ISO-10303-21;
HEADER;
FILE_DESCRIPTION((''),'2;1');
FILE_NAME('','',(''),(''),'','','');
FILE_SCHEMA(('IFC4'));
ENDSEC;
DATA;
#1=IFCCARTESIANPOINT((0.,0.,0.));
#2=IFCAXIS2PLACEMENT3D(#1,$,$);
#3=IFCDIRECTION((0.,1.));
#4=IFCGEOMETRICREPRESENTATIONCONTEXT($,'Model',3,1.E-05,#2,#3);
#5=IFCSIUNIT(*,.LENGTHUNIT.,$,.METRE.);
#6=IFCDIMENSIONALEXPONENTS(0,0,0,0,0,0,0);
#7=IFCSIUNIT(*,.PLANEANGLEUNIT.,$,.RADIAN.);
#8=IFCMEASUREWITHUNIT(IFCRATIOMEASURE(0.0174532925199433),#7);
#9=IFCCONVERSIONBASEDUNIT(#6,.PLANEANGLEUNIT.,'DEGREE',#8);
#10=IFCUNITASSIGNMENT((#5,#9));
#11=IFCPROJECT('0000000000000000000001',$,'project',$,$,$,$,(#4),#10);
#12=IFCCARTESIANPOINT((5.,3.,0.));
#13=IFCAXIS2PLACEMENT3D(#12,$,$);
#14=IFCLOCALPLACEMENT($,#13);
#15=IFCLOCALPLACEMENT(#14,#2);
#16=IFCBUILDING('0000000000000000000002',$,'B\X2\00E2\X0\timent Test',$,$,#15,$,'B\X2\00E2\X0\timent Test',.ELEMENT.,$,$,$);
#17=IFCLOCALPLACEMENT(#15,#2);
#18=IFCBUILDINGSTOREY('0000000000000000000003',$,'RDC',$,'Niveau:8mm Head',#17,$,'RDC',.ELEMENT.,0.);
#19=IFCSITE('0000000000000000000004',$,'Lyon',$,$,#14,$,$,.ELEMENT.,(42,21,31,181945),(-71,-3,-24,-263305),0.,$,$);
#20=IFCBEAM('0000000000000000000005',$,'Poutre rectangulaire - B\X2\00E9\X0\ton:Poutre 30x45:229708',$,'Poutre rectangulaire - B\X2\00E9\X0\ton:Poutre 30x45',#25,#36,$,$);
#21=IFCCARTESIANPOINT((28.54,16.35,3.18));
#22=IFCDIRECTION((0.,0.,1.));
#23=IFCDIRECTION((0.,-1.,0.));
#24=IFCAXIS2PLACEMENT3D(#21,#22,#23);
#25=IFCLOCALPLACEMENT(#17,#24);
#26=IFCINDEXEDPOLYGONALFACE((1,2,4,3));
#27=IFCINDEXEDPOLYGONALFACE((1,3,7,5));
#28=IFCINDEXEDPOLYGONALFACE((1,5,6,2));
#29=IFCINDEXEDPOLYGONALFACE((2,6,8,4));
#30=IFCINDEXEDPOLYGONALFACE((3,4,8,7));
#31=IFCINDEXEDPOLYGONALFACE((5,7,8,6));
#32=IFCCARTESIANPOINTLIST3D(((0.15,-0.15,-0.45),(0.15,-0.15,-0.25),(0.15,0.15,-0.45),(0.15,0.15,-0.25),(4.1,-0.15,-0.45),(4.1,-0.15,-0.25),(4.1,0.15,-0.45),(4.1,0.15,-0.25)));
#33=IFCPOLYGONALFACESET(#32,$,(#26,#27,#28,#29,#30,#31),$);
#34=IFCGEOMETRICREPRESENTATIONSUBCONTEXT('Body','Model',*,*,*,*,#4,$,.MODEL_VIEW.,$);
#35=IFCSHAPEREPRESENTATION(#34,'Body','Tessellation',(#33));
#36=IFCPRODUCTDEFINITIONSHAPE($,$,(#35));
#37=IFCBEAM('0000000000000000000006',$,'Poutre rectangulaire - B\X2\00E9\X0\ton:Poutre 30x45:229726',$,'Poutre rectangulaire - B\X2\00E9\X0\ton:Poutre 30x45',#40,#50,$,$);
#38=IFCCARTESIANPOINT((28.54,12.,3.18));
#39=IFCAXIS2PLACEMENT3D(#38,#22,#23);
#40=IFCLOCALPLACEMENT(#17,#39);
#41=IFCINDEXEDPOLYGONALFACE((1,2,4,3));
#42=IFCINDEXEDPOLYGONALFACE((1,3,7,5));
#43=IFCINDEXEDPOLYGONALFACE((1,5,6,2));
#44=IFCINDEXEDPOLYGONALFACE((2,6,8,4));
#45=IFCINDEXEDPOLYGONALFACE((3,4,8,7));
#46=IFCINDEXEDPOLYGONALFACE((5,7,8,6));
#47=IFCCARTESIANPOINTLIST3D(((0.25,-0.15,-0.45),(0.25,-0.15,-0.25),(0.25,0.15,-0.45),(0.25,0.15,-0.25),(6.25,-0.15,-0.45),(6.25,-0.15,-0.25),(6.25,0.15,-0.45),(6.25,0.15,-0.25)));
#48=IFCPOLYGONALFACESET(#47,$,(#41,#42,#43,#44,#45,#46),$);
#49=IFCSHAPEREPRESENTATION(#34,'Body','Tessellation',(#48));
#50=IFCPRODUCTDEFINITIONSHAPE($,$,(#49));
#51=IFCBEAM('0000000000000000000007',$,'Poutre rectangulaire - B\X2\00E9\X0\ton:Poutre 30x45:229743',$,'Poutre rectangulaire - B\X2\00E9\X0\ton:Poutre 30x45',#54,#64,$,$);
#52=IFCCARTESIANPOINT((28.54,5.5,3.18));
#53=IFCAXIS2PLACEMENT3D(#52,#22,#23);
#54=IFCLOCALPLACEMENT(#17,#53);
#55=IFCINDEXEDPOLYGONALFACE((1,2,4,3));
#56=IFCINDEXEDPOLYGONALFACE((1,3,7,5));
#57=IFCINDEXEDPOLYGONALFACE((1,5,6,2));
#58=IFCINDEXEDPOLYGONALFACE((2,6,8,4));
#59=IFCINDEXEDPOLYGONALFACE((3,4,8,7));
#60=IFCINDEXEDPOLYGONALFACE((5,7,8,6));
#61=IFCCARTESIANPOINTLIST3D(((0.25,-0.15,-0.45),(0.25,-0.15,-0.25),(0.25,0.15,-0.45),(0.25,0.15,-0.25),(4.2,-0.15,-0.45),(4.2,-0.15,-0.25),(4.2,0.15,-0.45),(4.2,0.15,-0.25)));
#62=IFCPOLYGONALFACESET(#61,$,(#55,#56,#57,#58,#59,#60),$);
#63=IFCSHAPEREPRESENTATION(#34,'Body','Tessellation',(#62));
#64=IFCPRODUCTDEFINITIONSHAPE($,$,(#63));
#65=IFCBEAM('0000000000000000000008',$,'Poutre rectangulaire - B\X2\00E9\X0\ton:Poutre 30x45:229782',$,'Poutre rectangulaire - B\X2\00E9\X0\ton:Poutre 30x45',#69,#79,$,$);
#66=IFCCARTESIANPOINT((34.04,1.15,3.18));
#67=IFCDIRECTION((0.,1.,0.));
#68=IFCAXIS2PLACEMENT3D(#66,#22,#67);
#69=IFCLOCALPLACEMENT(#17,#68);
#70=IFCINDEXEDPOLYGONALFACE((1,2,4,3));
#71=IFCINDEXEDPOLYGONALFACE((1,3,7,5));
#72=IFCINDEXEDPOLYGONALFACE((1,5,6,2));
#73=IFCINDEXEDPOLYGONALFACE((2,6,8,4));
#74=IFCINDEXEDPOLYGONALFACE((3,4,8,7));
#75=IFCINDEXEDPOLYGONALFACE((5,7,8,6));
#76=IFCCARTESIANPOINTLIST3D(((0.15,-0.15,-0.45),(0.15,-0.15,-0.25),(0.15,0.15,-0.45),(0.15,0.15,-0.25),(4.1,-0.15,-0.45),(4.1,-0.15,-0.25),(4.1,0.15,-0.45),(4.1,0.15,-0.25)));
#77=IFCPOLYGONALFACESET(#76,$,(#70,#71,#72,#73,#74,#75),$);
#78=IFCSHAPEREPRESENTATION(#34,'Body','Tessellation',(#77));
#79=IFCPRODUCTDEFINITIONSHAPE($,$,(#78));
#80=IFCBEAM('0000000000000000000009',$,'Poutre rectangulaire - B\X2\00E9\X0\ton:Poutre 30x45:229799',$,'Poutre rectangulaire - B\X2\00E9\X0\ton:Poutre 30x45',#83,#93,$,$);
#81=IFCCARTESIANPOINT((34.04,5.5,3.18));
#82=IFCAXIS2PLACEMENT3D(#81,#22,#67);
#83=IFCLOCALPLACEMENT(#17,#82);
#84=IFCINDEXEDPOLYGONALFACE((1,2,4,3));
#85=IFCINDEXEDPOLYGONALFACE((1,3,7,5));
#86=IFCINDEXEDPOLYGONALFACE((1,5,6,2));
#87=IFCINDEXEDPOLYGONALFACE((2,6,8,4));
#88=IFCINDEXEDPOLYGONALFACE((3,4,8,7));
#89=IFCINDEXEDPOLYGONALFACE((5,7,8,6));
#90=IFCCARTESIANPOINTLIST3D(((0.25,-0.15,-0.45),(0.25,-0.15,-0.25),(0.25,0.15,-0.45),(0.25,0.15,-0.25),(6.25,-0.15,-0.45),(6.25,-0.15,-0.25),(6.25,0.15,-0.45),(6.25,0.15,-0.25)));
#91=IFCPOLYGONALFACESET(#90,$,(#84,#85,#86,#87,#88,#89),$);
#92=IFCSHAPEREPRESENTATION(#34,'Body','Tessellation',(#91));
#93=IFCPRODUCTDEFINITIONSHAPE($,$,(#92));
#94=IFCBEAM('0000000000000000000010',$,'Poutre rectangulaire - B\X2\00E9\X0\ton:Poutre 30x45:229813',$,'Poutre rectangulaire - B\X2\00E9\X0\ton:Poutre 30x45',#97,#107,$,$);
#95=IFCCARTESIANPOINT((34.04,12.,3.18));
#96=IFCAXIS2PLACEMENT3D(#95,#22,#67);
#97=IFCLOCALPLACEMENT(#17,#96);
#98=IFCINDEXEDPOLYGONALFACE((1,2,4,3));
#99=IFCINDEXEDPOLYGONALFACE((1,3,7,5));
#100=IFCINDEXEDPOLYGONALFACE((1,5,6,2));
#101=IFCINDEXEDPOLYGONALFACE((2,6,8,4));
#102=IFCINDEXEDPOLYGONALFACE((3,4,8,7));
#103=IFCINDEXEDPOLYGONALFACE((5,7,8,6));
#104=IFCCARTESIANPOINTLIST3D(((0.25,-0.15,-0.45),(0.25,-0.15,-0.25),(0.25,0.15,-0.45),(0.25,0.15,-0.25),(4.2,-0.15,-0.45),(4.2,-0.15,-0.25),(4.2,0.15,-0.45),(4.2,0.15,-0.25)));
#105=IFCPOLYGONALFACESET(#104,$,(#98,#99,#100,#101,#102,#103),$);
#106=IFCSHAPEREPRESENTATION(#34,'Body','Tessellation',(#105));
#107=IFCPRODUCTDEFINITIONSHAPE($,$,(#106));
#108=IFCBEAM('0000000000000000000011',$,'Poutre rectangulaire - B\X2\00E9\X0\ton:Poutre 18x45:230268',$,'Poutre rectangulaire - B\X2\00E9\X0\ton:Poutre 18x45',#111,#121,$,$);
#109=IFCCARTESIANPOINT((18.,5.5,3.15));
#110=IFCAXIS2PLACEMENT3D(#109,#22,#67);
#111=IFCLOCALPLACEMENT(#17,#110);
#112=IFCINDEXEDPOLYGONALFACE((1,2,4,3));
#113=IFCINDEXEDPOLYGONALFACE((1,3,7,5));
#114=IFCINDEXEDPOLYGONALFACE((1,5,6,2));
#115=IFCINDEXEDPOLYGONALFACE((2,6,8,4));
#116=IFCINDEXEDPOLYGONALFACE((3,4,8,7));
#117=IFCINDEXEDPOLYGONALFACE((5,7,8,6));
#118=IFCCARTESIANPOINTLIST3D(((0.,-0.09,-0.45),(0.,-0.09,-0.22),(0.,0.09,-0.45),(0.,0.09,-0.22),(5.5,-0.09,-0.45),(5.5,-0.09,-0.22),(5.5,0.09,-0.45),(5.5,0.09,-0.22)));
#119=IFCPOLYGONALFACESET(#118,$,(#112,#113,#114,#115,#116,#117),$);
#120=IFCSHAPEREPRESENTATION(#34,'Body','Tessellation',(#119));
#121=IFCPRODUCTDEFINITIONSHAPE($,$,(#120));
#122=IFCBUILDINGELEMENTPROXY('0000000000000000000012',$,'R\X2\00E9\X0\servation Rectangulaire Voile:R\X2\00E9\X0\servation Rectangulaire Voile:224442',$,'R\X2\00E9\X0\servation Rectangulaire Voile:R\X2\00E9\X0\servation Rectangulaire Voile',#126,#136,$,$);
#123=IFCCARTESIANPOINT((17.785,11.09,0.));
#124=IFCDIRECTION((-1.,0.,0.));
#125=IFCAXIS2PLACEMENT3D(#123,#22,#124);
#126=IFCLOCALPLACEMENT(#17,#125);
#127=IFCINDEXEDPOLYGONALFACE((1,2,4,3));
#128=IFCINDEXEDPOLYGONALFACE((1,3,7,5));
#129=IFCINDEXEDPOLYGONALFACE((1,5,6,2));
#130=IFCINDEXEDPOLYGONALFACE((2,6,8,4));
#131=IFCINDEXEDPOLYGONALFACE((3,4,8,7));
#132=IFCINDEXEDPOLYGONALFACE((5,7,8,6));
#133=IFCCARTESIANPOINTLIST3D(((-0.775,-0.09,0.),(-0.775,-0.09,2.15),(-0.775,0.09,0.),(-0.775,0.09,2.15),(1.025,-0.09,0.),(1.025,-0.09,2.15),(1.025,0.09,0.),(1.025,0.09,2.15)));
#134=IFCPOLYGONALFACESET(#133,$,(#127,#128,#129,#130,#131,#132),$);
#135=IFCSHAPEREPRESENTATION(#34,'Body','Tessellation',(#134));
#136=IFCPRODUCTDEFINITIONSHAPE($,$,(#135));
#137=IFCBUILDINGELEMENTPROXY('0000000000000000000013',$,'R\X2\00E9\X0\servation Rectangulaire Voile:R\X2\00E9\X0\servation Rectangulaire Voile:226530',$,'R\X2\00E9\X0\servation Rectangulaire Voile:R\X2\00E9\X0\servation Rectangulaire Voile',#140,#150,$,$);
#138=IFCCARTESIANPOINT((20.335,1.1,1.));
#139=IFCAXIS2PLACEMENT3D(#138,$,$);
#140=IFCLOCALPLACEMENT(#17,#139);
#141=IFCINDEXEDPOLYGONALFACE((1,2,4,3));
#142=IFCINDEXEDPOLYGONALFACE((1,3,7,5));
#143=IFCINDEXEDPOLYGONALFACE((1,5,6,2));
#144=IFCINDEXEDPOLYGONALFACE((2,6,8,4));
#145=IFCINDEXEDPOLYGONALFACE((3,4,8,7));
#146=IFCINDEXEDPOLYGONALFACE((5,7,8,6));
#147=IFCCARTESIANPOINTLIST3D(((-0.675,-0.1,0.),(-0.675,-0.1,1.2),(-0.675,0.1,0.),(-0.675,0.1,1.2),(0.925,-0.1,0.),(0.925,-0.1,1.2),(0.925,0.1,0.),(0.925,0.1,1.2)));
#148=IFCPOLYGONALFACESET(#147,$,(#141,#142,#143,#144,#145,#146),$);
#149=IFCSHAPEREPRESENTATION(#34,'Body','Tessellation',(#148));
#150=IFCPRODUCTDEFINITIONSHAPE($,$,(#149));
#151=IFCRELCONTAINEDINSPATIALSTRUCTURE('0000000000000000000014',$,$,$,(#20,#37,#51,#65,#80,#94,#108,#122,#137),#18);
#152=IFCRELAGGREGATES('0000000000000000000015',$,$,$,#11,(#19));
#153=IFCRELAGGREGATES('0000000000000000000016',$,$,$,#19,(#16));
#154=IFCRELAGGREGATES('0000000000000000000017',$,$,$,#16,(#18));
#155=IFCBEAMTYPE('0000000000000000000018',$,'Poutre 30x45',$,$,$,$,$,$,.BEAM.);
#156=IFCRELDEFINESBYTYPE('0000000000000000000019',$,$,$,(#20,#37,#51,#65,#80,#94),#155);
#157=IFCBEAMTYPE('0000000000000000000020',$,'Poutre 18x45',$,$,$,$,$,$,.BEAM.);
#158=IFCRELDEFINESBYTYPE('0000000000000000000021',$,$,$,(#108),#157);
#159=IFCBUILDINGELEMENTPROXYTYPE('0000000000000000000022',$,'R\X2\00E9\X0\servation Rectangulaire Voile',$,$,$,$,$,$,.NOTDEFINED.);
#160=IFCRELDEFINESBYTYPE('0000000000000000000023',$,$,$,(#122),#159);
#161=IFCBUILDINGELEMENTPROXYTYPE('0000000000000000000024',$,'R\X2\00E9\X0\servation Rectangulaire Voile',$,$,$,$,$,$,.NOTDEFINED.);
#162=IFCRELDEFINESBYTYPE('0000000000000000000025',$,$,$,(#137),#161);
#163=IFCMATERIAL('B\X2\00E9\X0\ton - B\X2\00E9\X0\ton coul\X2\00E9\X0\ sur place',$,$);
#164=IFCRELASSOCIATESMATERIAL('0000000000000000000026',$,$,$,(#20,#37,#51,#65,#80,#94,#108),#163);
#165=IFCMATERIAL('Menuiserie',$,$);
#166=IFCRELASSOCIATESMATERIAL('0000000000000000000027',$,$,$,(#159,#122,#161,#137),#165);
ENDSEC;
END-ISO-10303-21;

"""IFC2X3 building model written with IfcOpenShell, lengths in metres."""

from ifc_helpers import new_model, entity, si_unit, converted_unit, direction, frame, frame_2d, origin, origin_2d_with_axis, place, context, subcontext, project, spatial, rectangle, extrude, source, transform, mapped, material, type_object, type_shapes, element, save


model = new_model("IFC2X3")

# Units and contexts
model_context = context("Model", 3, precision=1e-05, world=origin(), true_north=direction((0.0, 1.0)))
body_context = subcontext(model_context, "Body", "Model", "MODEL_VIEW")
ifc_project = project(units=[si_unit("LENGTHUNIT", "METRE"), converted_unit("PLANEANGLEUNIT", "DEGREE", entity("IfcRatioMeasure", 0.0174532925199433), si_unit("PLANEANGLEUNIT", "RADIAN"), dimensions=[0, 0, 0, 0, 0, 0, 0])], contexts=[model_context])

# Site, building, storey
site_placement = place(None, frame((5.0, 3.0, 0.0)))
site = spatial("IfcSite", under=ifc_project, at=site_placement, Name="Lyon", CompositionType="ELEMENT", RefLatitude=(42, 21, 31, 181945), RefLongitude=(-71, -3, -24, -263305), RefElevation=0.0)
building_placement = place(site_placement, origin())
building = spatial("IfcBuilding", under=site, at=building_placement, Name="Bâtiment Test", LongName="Bâtiment Test", CompositionType="ELEMENT")
storey_placement = place(building_placement, origin())
storey = spatial("IfcBuildingStorey", under=building, at=storey_placement, Name="RDC", ObjectType="Niveau:8mm Head", LongName="RDC", CompositionType="ELEMENT", Elevation=0.0)

# Beams
ifc_material_1 = material(Name="Béton - Béton coulé sur place")
beam_type_1 = type_object("IfcBeamType", Name="Poutre 30x45", PredefinedType="BEAM")
beam_1_placement = place(storey_placement, frame((28.54, 16.35, 3.18), z_axis=(0.0, 0.0, 1.0), x_axis=(0.0, -1.0, 0.0)))
element("IfcBeam", 1, at=beam_1_placement, inside=storey, type_object=beam_type_1, material=ifc_material_1, Name="Poutre rectangulaire - Béton:Poutre 30x45:229708", ObjectType="Poutre rectangulaire - Béton:Poutre 30x45", context=body_context, shape_type="SweptSolid", body=[
    extrude(rectangle(XDim=0.2, YDim=0.3, at=frame_2d((0.0, 0.0), x_axis=(1.0, 0.0))), frame((0.15, 0.0, -0.35), z_axis=(1.0, 0.0, 0.0), x_axis=(0.0, 0.0, -1.0)), (0.0, 0.0, 1.0), 3.95),
])
beam_2_placement = place(storey_placement, frame((28.54, 12.0, 3.18), z_axis=(0.0, 0.0, 1.0), x_axis=(0.0, -1.0, 0.0)))
element("IfcBeam", 2, at=beam_2_placement, inside=storey, type_object=beam_type_1, material=ifc_material_1, Name="Poutre rectangulaire - Béton:Poutre 30x45:229726", ObjectType="Poutre rectangulaire - Béton:Poutre 30x45", context=body_context, shape_type="SweptSolid", body=[
    extrude(rectangle(XDim=0.2, YDim=0.3, at=frame_2d((0.0, 0.0), x_axis=(1.0, 0.0))), frame((0.25, 0.0, -0.35), z_axis=(1.0, 0.0, 0.0), x_axis=(0.0, 0.0, -1.0)), (0.0, 0.0, 1.0), 6.0),
])
beam_3_placement = place(storey_placement, frame((28.54, 5.5, 3.18), z_axis=(0.0, 0.0, 1.0), x_axis=(0.0, -1.0, 0.0)))
element("IfcBeam", 3, at=beam_3_placement, inside=storey, type_object=beam_type_1, material=ifc_material_1, Name="Poutre rectangulaire - Béton:Poutre 30x45:229743", ObjectType="Poutre rectangulaire - Béton:Poutre 30x45", context=body_context, shape_type="SweptSolid", body=[
    extrude(rectangle(XDim=0.2, YDim=0.3, at=frame_2d((0.0, 0.0), x_axis=(1.0, 0.0))), frame((0.25, 0.0, -0.35), z_axis=(1.0, 0.0, 0.0), x_axis=(0.0, 0.0, -1.0)), (0.0, 0.0, 1.0), 3.95),
])
beam_4_placement = place(storey_placement, frame((34.04, 1.15, 3.18), z_axis=(0.0, 0.0, 1.0), x_axis=(0.0, 1.0, 0.0)))
element("IfcBeam", 4, at=beam_4_placement, inside=storey, type_object=beam_type_1, material=ifc_material_1, Name="Poutre rectangulaire - Béton:Poutre 30x45:229782", ObjectType="Poutre rectangulaire - Béton:Poutre 30x45", context=body_context, shape_type="SweptSolid", body=[
    extrude(rectangle(XDim=0.2, YDim=0.3, at=frame_2d((0.0, 0.0), x_axis=(1.0, 0.0))), frame((0.15, 0.0, -0.35), z_axis=(1.0, 0.0, 0.0), x_axis=(0.0, 0.0, -1.0)), (0.0, 0.0, 1.0), 3.95),
])
beam_5_placement = place(storey_placement, frame((34.04, 5.5, 3.18), z_axis=(0.0, 0.0, 1.0), x_axis=(0.0, 1.0, 0.0)))
element("IfcBeam", 5, at=beam_5_placement, inside=storey, type_object=beam_type_1, material=ifc_material_1, Name="Poutre rectangulaire - Béton:Poutre 30x45:229799", ObjectType="Poutre rectangulaire - Béton:Poutre 30x45", context=body_context, shape_type="SweptSolid", body=[
    extrude(rectangle(XDim=0.2, YDim=0.3, at=frame_2d((0.0, 0.0), x_axis=(1.0, 0.0))), frame((0.25, 0.0, -0.35), z_axis=(1.0, 0.0, 0.0), x_axis=(0.0, 0.0, -1.0)), (0.0, 0.0, 1.0), 6.0),
])
beam_6_placement = place(storey_placement, frame((34.04, 12.0, 3.18), z_axis=(0.0, 0.0, 1.0), x_axis=(0.0, 1.0, 0.0)))
element("IfcBeam", 6, at=beam_6_placement, inside=storey, type_object=beam_type_1, material=ifc_material_1, Name="Poutre rectangulaire - Béton:Poutre 30x45:229813", ObjectType="Poutre rectangulaire - Béton:Poutre 30x45", context=body_context, shape_type="SweptSolid", body=[
    extrude(rectangle(XDim=0.2, YDim=0.3, at=frame_2d((0.0, 0.0), x_axis=(1.0, 0.0))), frame((0.25, 0.0, -0.35), z_axis=(1.0, 0.0, 0.0), x_axis=(0.0, 0.0, -1.0)), (0.0, 0.0, 1.0), 3.95),
])
beam_type_2 = type_object("IfcBeamType", Name="Poutre 18x45", PredefinedType="BEAM")
beam_7_placement = place(storey_placement, frame((18.0, 5.5, 3.15), z_axis=(0.0, 0.0, 1.0), x_axis=(0.0, 1.0, 0.0)))
element("IfcBeam", 7, at=beam_7_placement, inside=storey, type_object=beam_type_2, material=ifc_material_1, Name="Poutre rectangulaire - Béton:Poutre 18x45:230268", ObjectType="Poutre rectangulaire - Béton:Poutre 18x45", context=body_context, shape_type="SweptSolid", body=[
    extrude(rectangle(XDim=0.23, YDim=0.18, at=frame_2d((0.0, 0.0), x_axis=(1.0, 0.0))), frame((0.0, 0.0, -0.335), z_axis=(1.0, 0.0, 0.0), x_axis=(0.0, 0.0, -1.0)), (0.0, 0.0, 1.0), 5.5),
])

# Building element proxies
ifc_material_2 = material(Name="Menuiserie")
building_element_proxy_type_1 = type_object("IfcBuildingElementProxyType", Name="Réservation Rectangulaire Voile", PredefinedType="NOTDEFINED", material=ifc_material_2)
shared_shape_1 = source(origin(), body_context, "Body", "SweptSolid", [
    extrude(rectangle(XDim=0.18, YDim=1.8, at=origin_2d_with_axis()), frame((0.125, 0.0, 0.0), z_axis=(0.0, 0.0, 1.0), x_axis=(0.0, 1.0, 0.0)), (0.0, 0.0, 1.0), 2.15),
])
type_shapes(building_element_proxy_type_1, [shared_shape_1])
proxy_1_placement = place(storey_placement, frame((17.785, 11.09, 0.0), z_axis=(0.0, 0.0, 1.0), x_axis=(-1.0, 0.0, 0.0)))
element("IfcBuildingElementProxy", 8, at=proxy_1_placement, inside=storey, type_object=building_element_proxy_type_1, material=ifc_material_2, Name="Réservation Rectangulaire Voile:Réservation Rectangulaire Voile:224442", ObjectType="Réservation Rectangulaire Voile:Réservation Rectangulaire Voile", context=body_context, shape_type="MappedRepresentation", body=[
    mapped(shared_shape_1, transform((0.0, 0.0, 0.0), scale=1.0)),
])
building_element_proxy_type_2 = type_object("IfcBuildingElementProxyType", Name="Réservation Rectangulaire Voile", PredefinedType="NOTDEFINED", material=ifc_material_2)
shared_shape_2 = source(origin(), body_context, "Body", "SweptSolid", [
    extrude(rectangle(XDim=0.2, YDim=1.6, at=origin_2d_with_axis()), frame((0.125, 0.0, 0.0), z_axis=(0.0, 0.0, 1.0), x_axis=(0.0, 1.0, 0.0)), (0.0, 0.0, 1.0), 1.2),
])
type_shapes(building_element_proxy_type_2, [shared_shape_2])
proxy_2_placement = place(storey_placement, frame((20.335, 1.1, 1.0)))
element("IfcBuildingElementProxy", 9, at=proxy_2_placement, inside=storey, type_object=building_element_proxy_type_2, material=ifc_material_2, Name="Réservation Rectangulaire Voile:Réservation Rectangulaire Voile:226530", ObjectType="Réservation Rectangulaire Voile:Réservation Rectangulaire Voile", context=body_context, shape_type="MappedRepresentation", body=[
    mapped(shared_shape_2, transform((0.0, 0.0, 0.0), scale=1.0)),
])

save(model, "model.ifc")
